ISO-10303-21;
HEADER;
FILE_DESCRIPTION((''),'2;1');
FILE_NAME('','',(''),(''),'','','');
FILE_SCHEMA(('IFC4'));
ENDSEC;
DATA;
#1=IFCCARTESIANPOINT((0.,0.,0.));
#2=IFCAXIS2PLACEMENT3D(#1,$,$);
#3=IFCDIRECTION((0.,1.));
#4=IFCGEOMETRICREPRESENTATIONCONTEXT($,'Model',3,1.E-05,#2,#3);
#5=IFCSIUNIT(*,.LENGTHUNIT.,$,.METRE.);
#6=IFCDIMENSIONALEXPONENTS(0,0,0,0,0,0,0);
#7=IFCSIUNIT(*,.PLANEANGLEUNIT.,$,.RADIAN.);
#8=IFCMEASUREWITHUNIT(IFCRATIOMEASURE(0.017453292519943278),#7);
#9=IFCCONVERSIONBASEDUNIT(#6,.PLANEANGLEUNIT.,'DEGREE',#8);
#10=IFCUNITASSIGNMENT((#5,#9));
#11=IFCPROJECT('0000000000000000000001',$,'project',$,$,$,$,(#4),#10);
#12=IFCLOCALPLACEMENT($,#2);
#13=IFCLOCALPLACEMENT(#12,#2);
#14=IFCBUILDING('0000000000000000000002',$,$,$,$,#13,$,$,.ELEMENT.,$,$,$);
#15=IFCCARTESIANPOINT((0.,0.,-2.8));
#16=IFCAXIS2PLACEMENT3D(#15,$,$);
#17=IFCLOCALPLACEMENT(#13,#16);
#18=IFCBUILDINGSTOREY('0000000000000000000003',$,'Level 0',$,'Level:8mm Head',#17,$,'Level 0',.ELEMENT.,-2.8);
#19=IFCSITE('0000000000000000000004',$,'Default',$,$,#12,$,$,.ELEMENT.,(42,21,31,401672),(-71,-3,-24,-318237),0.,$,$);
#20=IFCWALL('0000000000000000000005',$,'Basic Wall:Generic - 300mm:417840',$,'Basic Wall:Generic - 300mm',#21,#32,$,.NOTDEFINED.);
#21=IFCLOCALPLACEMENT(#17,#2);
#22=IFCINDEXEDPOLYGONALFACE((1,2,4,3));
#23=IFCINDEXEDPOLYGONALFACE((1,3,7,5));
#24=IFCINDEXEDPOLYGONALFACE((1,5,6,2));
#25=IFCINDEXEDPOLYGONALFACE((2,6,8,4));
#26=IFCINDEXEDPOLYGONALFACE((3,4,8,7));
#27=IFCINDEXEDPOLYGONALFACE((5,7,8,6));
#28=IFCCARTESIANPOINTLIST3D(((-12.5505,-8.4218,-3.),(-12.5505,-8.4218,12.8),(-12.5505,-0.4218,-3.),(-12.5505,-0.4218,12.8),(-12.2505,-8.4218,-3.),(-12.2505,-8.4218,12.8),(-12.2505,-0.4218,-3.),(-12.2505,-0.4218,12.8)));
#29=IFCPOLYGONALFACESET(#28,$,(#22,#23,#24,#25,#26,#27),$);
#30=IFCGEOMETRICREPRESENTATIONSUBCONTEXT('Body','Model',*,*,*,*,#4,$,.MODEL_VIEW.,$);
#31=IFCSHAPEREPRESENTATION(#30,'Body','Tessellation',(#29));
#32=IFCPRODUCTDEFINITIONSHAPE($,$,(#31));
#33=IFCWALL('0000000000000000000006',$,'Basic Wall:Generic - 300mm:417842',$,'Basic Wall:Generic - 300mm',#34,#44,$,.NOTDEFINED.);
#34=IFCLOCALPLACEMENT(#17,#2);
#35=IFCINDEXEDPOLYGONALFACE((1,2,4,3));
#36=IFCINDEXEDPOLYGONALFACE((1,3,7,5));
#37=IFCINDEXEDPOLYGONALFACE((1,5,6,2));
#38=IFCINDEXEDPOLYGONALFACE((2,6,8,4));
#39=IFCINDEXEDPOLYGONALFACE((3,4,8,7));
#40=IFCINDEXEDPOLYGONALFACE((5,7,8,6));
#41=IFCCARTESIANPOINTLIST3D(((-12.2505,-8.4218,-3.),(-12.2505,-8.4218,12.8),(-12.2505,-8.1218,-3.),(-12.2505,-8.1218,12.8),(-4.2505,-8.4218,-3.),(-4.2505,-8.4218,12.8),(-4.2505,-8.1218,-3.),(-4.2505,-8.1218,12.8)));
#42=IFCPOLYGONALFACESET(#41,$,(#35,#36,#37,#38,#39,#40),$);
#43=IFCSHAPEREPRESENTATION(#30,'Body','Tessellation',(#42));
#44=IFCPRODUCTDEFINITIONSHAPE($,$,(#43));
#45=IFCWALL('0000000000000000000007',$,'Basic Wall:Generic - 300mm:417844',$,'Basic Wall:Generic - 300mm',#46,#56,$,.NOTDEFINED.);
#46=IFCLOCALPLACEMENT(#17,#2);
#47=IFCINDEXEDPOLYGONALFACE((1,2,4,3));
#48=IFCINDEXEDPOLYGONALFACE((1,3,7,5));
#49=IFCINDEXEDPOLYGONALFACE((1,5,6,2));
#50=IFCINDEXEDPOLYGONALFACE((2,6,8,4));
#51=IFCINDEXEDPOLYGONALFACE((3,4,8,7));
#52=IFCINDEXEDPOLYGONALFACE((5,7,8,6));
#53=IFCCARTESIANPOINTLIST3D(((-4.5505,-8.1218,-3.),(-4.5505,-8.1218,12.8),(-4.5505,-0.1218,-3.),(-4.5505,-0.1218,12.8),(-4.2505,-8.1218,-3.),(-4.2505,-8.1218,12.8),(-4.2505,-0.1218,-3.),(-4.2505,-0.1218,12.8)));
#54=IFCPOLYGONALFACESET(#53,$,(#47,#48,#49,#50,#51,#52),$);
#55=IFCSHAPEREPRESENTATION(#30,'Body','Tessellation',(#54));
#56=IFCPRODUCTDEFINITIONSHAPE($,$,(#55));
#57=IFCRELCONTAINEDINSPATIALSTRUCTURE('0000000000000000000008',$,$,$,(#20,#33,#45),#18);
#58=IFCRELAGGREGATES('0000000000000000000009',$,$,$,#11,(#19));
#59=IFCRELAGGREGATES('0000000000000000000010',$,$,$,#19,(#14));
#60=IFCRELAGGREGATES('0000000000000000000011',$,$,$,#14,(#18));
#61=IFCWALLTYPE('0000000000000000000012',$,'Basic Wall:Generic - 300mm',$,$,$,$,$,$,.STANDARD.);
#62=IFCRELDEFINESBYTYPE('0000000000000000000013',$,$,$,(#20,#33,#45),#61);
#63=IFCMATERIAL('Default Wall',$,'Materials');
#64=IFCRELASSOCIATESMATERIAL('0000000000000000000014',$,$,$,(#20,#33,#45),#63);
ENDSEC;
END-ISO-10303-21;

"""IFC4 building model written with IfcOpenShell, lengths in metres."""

from ifc_helpers import new_model, entity, si_unit, converted_unit, direction, frame, origin, place, context, subcontext, project, spatial, indexed_curve, outline, extrude, material, type_object, element, save


model = new_model("IFC4")

# Units and contexts
model_context = context("Model", 3, precision=1e-05, world=origin(), true_north=direction((0.0, 1.0)))
body_context = subcontext(model_context, "Body", "Model", "MODEL_VIEW")
ifc_project = project(units=[si_unit("LENGTHUNIT", "METRE"), converted_unit("PLANEANGLEUNIT", "DEGREE", entity("IfcRatioMeasure", 0.017453292519943278), si_unit("PLANEANGLEUNIT", "RADIAN"), dimensions=[0, 0, 0, 0, 0, 0, 0])], contexts=[model_context])

# Site, building, storey
site_placement = place(None, origin())
site = spatial("IfcSite", under=ifc_project, at=site_placement, Name="Default", CompositionType="ELEMENT", RefLatitude=(42, 21, 31, 401672), RefLongitude=(-71, -3, -24, -318237), RefElevation=0.0)
building_placement = place(site_placement, origin())
building = spatial("IfcBuilding", under=site, at=building_placement, CompositionType="ELEMENT")
storey_placement = place(building_placement, frame((0.0, 0.0, -2.8)))
storey = spatial("IfcBuildingStorey", under=building, at=storey_placement, Name="Level 0", ObjectType="Level:8mm Head", LongName="Level 0", CompositionType="ELEMENT", Elevation=-2.8)

# Walls
ifc_material_1 = material(Name="Default Wall", Category="Materials")
wall_type = type_object("IfcWallType", Name="Basic Wall:Generic - 300mm", PredefinedType="STANDARD")
wall_1_placement = place(storey_placement, frame((-12.4005, -8.4218, -3.0), z_axis=(0.0, 0.0, 1.0), x_axis=(0.0, 1.0, 0.0)))
element("IfcWall", 1, at=wall_1_placement, inside=storey, type_object=wall_type, material=ifc_material_1, Name="Basic Wall:Generic - 300mm:417840", ObjectType="Basic Wall:Generic - 300mm", PredefinedType="NOTDEFINED", context=body_context, shape_type="SweptSolid", body=[
    extrude(outline(indexed_curve([(8.0, 0.15), (0.0, 0.15), (0.0, -0.15), (8.0, -0.15), (8.0, 0.15)], self_intersect=False)), origin(), (0.0, 0.0, 1.0), 15.8),
])
wall_2_placement = place(storey_placement, frame((-4.2505, -8.2718, -3.0), z_axis=(0.0, 0.0, 1.0), x_axis=(-1.0, 0.0, 0.0)))
element("IfcWall", 2, at=wall_2_placement, inside=storey, type_object=wall_type, material=ifc_material_1, Name="Basic Wall:Generic - 300mm:417842", ObjectType="Basic Wall:Generic - 300mm", PredefinedType="NOTDEFINED", context=body_context, shape_type="SweptSolid", body=[
    extrude(outline(indexed_curve([(8.0, 0.15), (0.0, 0.15), (0.0, -0.15), (8.0, -0.15), (8.0, 0.15)], self_intersect=False)), origin(), (0.0, 0.0, 1.0), 15.8),
])
wall_3_placement = place(storey_placement, frame((-4.4005, -0.1218, -3.0), z_axis=(0.0, 0.0, 1.0), x_axis=(0.0, -1.0, 0.0)))
element("IfcWall", 3, at=wall_3_placement, inside=storey, type_object=wall_type, material=ifc_material_1, Name="Basic Wall:Generic - 300mm:417844", ObjectType="Basic Wall:Generic - 300mm", PredefinedType="NOTDEFINED", context=body_context, shape_type="SweptSolid", body=[
    extrude(outline(indexed_curve([(8.0, 0.15), (0.0, 0.15), (0.0, -0.15), (8.0, -0.15), (8.0, 0.15)], self_intersect=False)), origin(), (0.0, 0.0, 1.0), 15.8),
])

save(model, "model.ifc")
